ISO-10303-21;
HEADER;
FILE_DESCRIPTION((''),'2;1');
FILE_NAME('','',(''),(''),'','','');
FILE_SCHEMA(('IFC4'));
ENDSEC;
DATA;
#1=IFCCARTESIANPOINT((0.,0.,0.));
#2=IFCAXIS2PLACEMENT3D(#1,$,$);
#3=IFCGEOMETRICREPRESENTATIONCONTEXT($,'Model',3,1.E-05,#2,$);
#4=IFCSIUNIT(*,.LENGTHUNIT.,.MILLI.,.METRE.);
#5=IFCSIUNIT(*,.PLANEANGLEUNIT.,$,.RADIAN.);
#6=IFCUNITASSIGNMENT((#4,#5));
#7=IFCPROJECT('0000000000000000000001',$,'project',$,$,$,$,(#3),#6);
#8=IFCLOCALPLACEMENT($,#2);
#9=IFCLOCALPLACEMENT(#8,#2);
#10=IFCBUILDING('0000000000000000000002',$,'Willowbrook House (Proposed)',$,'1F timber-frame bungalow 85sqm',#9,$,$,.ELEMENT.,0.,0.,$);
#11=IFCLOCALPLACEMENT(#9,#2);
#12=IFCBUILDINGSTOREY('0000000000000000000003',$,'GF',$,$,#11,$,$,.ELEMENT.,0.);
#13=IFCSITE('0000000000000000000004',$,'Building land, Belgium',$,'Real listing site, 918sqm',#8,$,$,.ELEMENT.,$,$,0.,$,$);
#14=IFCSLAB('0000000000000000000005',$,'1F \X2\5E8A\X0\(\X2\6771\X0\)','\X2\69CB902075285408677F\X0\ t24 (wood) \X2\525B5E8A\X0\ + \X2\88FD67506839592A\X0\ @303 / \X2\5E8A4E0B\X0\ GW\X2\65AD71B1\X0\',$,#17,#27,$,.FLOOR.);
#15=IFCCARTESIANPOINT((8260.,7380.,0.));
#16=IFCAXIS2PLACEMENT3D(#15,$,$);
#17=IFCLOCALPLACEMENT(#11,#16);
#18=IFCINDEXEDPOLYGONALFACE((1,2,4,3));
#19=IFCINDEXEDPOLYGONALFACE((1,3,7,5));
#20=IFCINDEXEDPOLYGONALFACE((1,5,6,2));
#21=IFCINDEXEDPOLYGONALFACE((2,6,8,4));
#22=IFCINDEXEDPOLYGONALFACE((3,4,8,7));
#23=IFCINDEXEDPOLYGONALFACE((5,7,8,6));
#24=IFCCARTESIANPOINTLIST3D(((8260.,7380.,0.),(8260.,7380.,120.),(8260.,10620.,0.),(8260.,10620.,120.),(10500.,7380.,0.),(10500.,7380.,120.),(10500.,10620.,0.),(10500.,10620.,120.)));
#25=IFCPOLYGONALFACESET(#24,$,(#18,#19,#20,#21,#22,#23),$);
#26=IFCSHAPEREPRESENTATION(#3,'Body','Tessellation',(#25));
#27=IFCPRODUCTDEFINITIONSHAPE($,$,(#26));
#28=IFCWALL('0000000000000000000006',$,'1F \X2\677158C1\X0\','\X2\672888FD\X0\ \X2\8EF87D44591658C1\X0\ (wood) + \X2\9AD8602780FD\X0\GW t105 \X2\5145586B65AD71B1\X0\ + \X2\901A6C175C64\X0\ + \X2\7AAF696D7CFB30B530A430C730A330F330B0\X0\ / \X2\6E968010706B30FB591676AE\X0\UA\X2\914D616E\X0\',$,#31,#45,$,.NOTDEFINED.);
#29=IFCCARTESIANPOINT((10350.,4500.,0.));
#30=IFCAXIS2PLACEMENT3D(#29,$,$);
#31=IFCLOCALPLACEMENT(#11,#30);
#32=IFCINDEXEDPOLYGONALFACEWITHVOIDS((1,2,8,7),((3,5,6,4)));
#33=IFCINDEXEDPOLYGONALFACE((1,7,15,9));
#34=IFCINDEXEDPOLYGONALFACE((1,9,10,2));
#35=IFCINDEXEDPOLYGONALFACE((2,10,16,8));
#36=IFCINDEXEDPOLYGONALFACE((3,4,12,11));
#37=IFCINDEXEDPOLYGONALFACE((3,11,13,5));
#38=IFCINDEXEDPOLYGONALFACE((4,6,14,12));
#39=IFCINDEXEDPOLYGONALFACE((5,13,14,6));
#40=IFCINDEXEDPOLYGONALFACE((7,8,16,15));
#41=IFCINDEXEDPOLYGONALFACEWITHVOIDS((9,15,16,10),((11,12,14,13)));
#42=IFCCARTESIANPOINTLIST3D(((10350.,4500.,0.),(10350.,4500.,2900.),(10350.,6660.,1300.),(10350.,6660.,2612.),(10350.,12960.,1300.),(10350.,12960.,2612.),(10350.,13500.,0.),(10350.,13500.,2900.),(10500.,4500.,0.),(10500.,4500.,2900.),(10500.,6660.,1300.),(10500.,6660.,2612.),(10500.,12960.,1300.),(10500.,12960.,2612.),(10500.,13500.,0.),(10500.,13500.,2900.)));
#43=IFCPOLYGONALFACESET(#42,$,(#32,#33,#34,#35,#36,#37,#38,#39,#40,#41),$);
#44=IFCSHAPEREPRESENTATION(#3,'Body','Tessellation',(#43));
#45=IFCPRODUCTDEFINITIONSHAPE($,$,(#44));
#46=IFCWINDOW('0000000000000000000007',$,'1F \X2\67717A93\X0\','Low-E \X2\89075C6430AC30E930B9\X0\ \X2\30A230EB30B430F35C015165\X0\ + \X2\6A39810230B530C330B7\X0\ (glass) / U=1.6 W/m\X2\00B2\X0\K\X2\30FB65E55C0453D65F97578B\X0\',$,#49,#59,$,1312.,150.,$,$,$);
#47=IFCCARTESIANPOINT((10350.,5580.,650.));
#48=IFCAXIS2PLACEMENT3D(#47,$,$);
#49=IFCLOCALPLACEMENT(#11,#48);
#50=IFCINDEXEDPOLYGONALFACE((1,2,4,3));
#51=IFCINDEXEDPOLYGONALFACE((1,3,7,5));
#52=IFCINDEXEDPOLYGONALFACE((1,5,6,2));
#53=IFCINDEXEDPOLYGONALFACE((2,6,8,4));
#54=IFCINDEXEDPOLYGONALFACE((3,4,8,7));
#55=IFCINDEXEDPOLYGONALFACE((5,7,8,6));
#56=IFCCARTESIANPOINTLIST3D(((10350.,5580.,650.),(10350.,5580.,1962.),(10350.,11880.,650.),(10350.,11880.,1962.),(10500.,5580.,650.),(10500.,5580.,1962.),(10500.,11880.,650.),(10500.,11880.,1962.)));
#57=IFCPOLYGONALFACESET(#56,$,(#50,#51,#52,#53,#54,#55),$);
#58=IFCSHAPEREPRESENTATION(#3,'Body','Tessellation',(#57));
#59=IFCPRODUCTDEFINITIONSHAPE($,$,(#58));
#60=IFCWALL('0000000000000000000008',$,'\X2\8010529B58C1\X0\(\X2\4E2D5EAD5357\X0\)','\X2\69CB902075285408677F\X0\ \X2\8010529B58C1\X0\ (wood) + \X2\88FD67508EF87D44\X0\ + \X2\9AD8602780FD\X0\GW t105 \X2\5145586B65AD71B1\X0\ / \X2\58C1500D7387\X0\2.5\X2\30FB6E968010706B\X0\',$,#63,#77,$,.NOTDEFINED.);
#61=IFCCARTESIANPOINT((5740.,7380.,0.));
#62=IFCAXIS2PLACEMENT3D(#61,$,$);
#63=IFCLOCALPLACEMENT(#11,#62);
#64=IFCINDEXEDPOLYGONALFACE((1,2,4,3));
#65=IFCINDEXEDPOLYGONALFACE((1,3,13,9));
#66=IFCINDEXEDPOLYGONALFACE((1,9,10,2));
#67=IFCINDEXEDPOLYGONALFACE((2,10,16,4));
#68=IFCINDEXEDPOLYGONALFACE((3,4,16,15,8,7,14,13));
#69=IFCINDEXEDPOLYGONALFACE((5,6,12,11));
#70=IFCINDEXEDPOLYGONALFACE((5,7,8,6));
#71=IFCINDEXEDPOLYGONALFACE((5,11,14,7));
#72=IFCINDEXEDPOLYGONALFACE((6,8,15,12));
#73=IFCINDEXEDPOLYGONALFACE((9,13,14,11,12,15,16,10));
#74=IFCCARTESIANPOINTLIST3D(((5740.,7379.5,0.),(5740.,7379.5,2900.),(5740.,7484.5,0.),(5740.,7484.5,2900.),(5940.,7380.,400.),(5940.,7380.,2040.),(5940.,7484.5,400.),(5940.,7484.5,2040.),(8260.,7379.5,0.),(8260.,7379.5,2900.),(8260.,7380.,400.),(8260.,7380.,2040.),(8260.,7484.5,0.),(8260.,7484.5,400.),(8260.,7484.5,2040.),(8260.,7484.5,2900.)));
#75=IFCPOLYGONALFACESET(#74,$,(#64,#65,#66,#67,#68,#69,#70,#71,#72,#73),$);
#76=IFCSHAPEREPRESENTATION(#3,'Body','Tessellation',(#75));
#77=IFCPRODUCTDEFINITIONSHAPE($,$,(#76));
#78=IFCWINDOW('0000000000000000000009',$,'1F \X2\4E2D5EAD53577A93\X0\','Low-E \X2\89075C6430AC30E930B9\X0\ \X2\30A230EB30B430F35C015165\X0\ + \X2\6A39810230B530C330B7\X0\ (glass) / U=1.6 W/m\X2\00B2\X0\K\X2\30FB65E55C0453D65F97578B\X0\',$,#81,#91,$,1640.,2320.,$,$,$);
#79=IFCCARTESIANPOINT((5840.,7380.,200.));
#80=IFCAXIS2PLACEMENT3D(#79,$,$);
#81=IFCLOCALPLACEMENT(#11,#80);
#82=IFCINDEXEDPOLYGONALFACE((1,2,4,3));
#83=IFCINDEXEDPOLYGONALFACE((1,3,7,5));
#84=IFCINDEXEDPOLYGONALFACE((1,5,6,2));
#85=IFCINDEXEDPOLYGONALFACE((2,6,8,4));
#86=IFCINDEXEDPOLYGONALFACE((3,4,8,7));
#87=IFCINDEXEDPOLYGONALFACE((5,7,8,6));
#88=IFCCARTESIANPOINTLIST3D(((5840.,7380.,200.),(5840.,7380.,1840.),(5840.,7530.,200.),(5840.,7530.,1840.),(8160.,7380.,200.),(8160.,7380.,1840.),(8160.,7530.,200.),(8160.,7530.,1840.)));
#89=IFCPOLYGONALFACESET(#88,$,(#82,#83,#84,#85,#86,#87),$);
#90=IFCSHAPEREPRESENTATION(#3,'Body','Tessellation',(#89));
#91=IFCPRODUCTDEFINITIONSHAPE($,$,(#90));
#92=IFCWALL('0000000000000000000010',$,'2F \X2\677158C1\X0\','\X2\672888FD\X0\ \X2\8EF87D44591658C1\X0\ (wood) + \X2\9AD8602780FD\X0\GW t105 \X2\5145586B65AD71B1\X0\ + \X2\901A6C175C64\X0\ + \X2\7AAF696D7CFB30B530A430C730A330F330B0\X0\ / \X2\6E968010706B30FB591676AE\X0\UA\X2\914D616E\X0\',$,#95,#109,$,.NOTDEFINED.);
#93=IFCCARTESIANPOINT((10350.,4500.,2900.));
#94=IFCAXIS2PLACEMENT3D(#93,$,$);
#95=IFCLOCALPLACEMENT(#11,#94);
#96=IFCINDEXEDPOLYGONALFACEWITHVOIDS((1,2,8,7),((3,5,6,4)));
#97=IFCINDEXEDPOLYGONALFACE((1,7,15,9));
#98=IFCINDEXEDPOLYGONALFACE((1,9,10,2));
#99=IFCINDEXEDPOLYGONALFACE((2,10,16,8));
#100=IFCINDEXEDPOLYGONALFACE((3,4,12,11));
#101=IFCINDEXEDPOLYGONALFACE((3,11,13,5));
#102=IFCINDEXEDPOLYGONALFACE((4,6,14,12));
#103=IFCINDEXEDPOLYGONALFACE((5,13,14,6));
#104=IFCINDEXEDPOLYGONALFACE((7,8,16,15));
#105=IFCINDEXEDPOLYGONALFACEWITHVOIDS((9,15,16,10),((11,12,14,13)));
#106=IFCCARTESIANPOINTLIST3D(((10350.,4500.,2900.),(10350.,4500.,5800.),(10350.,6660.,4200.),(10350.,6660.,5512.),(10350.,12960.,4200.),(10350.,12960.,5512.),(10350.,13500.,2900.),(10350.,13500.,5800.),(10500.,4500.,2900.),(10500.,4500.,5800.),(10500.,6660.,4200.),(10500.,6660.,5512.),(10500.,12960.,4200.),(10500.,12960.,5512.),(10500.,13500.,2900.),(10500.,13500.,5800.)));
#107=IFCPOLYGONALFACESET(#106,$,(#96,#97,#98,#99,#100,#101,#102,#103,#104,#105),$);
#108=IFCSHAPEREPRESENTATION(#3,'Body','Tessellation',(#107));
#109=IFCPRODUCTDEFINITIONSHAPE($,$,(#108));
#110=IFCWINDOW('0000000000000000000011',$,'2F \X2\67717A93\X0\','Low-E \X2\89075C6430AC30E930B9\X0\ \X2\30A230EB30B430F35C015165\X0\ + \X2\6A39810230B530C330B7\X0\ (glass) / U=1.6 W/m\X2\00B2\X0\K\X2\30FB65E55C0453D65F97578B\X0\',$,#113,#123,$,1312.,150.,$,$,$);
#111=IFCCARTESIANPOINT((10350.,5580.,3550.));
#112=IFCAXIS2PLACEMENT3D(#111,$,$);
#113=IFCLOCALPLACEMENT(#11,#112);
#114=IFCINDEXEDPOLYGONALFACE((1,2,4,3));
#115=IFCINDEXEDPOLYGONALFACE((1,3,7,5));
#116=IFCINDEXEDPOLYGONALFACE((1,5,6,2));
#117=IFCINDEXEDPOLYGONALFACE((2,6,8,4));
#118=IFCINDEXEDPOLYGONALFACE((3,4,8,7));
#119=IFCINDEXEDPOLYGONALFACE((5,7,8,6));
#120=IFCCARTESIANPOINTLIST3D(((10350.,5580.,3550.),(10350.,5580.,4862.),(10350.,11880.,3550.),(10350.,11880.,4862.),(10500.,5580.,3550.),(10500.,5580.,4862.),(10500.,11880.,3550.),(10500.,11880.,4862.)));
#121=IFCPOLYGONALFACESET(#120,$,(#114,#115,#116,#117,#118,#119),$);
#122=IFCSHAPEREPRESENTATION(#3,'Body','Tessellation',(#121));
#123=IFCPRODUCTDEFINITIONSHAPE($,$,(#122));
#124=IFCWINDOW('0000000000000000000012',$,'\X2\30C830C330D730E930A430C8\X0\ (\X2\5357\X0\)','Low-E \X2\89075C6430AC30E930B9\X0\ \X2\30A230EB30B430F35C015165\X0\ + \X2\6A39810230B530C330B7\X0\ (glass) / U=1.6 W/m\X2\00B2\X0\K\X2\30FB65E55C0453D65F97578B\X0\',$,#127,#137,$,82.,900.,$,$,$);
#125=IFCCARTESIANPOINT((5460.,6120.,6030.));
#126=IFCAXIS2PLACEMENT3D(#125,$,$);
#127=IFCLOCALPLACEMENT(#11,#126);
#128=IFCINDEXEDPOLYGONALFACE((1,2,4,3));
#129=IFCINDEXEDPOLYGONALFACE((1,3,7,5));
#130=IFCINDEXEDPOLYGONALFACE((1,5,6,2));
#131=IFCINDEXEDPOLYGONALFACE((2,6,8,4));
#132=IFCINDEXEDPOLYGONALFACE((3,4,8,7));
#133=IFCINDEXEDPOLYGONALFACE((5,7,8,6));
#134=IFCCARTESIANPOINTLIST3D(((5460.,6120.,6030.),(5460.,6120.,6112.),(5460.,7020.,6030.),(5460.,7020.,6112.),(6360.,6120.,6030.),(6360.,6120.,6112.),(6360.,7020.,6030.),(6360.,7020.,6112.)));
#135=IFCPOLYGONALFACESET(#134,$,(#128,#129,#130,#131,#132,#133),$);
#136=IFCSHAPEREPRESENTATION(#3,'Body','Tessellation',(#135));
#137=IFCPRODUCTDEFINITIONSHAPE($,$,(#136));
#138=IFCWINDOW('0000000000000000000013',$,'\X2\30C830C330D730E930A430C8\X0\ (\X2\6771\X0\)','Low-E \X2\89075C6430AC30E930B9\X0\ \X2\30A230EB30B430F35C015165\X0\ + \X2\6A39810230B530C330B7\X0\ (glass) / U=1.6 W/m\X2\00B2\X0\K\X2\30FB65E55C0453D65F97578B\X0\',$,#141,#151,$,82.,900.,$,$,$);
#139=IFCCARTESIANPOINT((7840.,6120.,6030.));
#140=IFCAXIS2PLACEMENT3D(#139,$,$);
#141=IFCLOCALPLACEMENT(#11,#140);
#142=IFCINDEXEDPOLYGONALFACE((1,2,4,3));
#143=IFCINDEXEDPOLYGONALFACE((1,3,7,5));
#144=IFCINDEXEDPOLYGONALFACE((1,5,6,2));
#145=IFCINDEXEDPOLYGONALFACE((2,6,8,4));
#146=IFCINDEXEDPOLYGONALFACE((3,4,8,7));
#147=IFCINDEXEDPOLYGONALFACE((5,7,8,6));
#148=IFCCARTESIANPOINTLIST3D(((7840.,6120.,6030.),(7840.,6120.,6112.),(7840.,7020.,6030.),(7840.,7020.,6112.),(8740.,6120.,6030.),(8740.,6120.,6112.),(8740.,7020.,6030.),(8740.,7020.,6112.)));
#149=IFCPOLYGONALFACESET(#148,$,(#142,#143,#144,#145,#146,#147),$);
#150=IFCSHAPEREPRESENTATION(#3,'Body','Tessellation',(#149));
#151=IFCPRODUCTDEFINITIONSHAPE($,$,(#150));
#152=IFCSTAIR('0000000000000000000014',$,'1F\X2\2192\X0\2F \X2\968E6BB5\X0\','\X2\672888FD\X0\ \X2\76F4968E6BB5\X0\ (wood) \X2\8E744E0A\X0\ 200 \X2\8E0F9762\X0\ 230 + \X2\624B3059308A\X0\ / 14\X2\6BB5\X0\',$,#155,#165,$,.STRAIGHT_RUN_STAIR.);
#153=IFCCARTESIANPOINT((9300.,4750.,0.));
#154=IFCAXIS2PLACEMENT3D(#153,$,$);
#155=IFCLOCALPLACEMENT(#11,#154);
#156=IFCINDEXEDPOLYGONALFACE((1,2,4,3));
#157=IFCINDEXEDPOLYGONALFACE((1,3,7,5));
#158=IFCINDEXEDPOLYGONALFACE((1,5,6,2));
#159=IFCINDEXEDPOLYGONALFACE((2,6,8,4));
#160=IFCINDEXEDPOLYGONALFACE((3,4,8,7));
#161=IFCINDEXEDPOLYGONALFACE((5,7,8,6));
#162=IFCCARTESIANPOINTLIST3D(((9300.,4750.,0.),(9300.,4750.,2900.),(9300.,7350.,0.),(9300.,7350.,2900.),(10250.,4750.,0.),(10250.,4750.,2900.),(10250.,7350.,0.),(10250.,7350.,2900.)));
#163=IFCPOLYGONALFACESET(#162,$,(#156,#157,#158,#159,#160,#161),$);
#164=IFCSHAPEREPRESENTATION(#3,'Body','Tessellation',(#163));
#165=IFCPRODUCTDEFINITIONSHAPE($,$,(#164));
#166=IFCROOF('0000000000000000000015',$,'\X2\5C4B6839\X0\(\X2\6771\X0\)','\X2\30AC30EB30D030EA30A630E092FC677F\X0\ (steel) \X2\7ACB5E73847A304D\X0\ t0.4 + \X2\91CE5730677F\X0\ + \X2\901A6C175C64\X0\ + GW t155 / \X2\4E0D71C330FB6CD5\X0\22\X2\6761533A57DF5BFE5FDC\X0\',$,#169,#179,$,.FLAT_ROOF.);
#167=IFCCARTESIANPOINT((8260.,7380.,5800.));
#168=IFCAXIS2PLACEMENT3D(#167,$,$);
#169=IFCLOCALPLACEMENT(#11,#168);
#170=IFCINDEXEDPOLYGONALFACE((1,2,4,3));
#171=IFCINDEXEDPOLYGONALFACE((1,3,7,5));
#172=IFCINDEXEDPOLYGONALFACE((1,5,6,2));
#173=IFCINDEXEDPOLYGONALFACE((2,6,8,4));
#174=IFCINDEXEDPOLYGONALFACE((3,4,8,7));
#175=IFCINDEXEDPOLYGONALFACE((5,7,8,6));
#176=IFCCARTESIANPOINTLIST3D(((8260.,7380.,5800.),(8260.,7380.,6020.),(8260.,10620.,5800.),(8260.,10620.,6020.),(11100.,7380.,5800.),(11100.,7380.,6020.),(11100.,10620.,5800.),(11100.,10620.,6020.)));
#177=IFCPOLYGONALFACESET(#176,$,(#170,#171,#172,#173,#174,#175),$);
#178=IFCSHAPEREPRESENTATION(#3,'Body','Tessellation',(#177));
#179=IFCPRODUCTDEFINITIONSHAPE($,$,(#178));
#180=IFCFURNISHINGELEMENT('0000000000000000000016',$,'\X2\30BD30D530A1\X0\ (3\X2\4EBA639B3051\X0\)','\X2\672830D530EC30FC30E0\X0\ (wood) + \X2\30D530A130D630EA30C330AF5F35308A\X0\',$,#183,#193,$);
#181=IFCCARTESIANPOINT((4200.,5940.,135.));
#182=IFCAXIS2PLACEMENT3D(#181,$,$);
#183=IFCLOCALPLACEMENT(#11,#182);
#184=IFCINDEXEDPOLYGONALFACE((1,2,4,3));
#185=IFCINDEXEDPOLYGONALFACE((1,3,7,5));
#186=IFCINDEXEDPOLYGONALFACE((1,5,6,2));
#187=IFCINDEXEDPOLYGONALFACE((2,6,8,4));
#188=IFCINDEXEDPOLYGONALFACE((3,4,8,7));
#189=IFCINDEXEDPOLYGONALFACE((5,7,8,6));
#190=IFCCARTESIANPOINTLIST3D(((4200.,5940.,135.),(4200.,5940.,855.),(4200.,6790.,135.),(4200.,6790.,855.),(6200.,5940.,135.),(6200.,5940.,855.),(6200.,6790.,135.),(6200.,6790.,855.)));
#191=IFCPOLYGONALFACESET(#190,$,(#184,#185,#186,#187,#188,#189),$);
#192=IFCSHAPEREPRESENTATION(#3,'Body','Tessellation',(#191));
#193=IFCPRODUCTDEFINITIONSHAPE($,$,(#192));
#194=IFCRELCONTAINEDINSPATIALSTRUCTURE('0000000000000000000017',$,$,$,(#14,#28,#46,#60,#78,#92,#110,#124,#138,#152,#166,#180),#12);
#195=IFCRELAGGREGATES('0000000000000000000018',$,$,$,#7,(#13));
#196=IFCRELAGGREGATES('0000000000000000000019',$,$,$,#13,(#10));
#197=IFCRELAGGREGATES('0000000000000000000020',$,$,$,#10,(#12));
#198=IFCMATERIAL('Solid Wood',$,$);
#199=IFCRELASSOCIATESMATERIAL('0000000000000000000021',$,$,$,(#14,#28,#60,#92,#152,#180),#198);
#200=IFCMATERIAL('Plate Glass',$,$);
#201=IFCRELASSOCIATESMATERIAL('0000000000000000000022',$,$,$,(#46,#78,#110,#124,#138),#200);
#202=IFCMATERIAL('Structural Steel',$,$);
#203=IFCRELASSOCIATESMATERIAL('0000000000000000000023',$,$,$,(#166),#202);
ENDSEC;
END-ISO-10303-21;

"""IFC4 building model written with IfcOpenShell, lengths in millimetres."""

from ifc_helpers import new_model, si_unit, frame, frame_2d, origin, place, context, project, spatial, rectangle, extrude, material, element, fill, save


model = new_model("IFC4")

# Units and contexts
model_context = context("Model", 3, precision=1e-05, world=origin())
ifc_project = project(units=[si_unit("LENGTHUNIT", "METRE", prefix="MILLI"), si_unit("PLANEANGLEUNIT", "RADIAN")], contexts=[model_context])

# Site, building, storey
site_placement = place(None, origin())
site = spatial("IfcSite", under=ifc_project, at=site_placement, Name="Building land, Belgium", ObjectType="Real listing site, 918sqm", CompositionType="ELEMENT", RefElevation=0.0)
building_placement = place(site_placement, origin())
building = spatial("IfcBuilding", under=site, at=building_placement, Name="Willowbrook House (Proposed)", ObjectType="1F timber-frame bungalow 85sqm", CompositionType="ELEMENT", ElevationOfRefHeight=0.0, ElevationOfTerrain=0.0)
storey_placement = place(building_placement, origin())
storey = spatial("IfcBuildingStorey", under=building, at=storey_placement, Name="GF", CompositionType="ELEMENT", Elevation=0.0)

# Slab
ifc_material_1 = material(Name="Solid Wood")
slab_placement = place(storey_placement, frame((8260.0, 7380.0, 0.0)))
element("IfcSlab", 1, at=slab_placement, inside=storey, material=ifc_material_1, Name="1F 床(東)", Description="構造用合板 t24 (wood) 剛床 + 製材根太 @303 / 床下 GW断熱", PredefinedType="FLOOR", context=model_context, shape_type="SweptSolid", body=[
    extrude(rectangle(XDim=2240.0, YDim=3240.0, at=frame_2d((1120.0, 1620.0))), frame((8260.0, 7380.0, 0.0)), (0.0, 0.0, 1.0), 120.0),
])

# Walls, openings, windows
wall_1_placement = place(storey_placement, frame((10350.0, 4500.0, 0.0)))
wall_1 = element("IfcWall", 2, at=wall_1_placement, inside=storey, material=ifc_material_1, Name="1F 東壁", Description="木製 軸組外壁 (wood) + 高性能GW t105 充填断熱 + 通気層 + 窯業系サイディング / 準耐火・外皮UA配慮", PredefinedType="NOTDEFINED", context=model_context, shape_type="SweptSolid", body=[
    extrude(rectangle(XDim=150.0, YDim=9000.0, at=frame_2d((75.0, 4500.0))), frame((10350.0, 4500.0, 0.0)), (0.0, 0.0, 1.0), 2900.0),
])
opening_1_placement = place(storey_placement, frame((10350.0, 5580.0, 650.0)))
opening_1 = element("IfcOpeningElement", 3, at=opening_1_placement, cuts=wall_1, PredefinedType="NOTDEFINED", context=model_context, shape_type="SweptSolid", body=[
    extrude(rectangle(XDim=150.0, YDim=6300.0, at=frame_2d((75.0, 3150.0))), frame((10350.0, 5580.0, 650.0)), (0.0, 0.0, 1.0), 1312.0),
])
ifc_material_2 = material(Name="Plate Glass")
window_1_placement = place(storey_placement, frame((10350.0, 5580.0, 650.0)))
window_1 = element("IfcWindow", 4, at=window_1_placement, inside=storey, material=ifc_material_2, Name="1F 東窓", Description="Low-E 複層ガラス アルゴン封入 + 樹脂サッシ (glass) / U=1.6 W/m²K・日射取得型", OverallHeight=1312.0, OverallWidth=150.0, context=model_context, shape_type="SweptSolid", body=[
    extrude(rectangle(XDim=150.0, YDim=6300.0, at=frame_2d((75.0, 3150.0))), frame((10350.0, 5580.0, 650.0)), (0.0, 0.0, 1.0), 1312.0),
])
fill(opening_1, window_1)
wall_2_placement = place(storey_placement, frame((5740.0, 7380.0, 0.0)))
wall_2 = element("IfcWall", 5, at=wall_2_placement, inside=storey, material=ifc_material_1, Name="耐力壁(中庭南)", Description="構造用合板 耐力壁 (wood) + 製材軸組 + 高性能GW t105 充填断熱 / 壁倍率2.5・準耐火", PredefinedType="NOTDEFINED", context=model_context, shape_type="SweptSolid", body=[
    extrude(rectangle(XDim=2520.0, YDim=105.0, at=frame_2d((1260.0, 52.0))), frame((5740.0, 7380.0, 0.0)), (0.0, 0.0, 1.0), 2900.0),
])
opening_2_placement = place(storey_placement, frame((5840.0, 7380.0, 200.0)))
opening_2 = element("IfcOpeningElement", 6, at=opening_2_placement, cuts=wall_2, PredefinedType="NOTDEFINED", context=model_context, shape_type="SweptSolid", body=[
    extrude(rectangle(XDim=2320.0, YDim=150.0, at=frame_2d((1160.0, 75.0))), frame((5840.0, 7380.0, 200.0)), (0.0, 0.0, 1.0), 1640.0),
])
window_2_placement = place(storey_placement, frame((5840.0, 7380.0, 200.0)))
window_2 = element("IfcWindow", 7, at=window_2_placement, inside=storey, material=ifc_material_2, Name="1F 中庭南窓", Description="Low-E 複層ガラス アルゴン封入 + 樹脂サッシ (glass) / U=1.6 W/m²K・日射取得型", OverallHeight=1640.0, OverallWidth=2320.0, context=model_context, shape_type="SweptSolid", body=[
    extrude(rectangle(XDim=2320.0, YDim=150.0, at=frame_2d((1160.0, 75.0))), frame((5840.0, 7380.0, 200.0)), (0.0, 0.0, 1.0), 1640.0),
])
fill(opening_2, window_2)

# Wall, opening, window
wall_3_placement = place(storey_placement, frame((10350.0, 4500.0, 2900.0)))
wall_3 = element("IfcWall", 8, at=wall_3_placement, inside=storey, material=ifc_material_1, Name="2F 東壁", Description="木製 軸組外壁 (wood) + 高性能GW t105 充填断熱 + 通気層 + 窯業系サイディング / 準耐火・外皮UA配慮", PredefinedType="NOTDEFINED", context=model_context, shape_type="SweptSolid", body=[
    extrude(rectangle(XDim=150.0, YDim=9000.0, at=frame_2d((75.0, 4500.0))), frame((10350.0, 4500.0, 2900.0)), (0.0, 0.0, 1.0), 2900.0),
])
opening_3_placement = place(storey_placement, frame((10350.0, 5580.0, 3550.0)))
opening_3 = element("IfcOpeningElement", 9, at=opening_3_placement, cuts=wall_3, PredefinedType="NOTDEFINED", context=model_context, shape_type="SweptSolid", body=[
    extrude(rectangle(XDim=150.0, YDim=6300.0, at=frame_2d((75.0, 3150.0))), frame((10350.0, 5580.0, 3550.0)), (0.0, 0.0, 1.0), 1312.0),
])
window_3_placement = place(storey_placement, frame((10350.0, 5580.0, 3550.0)))
window_3 = element("IfcWindow", 10, at=window_3_placement, inside=storey, material=ifc_material_2, Name="2F 東窓", Description="Low-E 複層ガラス アルゴン封入 + 樹脂サッシ (glass) / U=1.6 W/m²K・日射取得型", OverallHeight=1312.0, OverallWidth=150.0, context=model_context, shape_type="SweptSolid", body=[
    extrude(rectangle(XDim=150.0, YDim=6300.0, at=frame_2d((75.0, 3150.0))), frame((10350.0, 5580.0, 3550.0)), (0.0, 0.0, 1.0), 1312.0),
])
fill(opening_3, window_3)

# Windows
window_4_placement = place(storey_placement, frame((5460.0, 6120.0, 6030.0)))
element("IfcWindow", 11, at=window_4_placement, inside=storey, material=ifc_material_2, Name="トップライト (南)", Description="Low-E 複層ガラス アルゴン封入 + 樹脂サッシ (glass) / U=1.6 W/m²K・日射取得型", OverallHeight=82.0, OverallWidth=900.0, context=model_context, shape_type="SweptSolid", body=[
    extrude(rectangle(XDim=900.0, YDim=900.0, at=frame_2d((450.0, 450.0))), frame((5460.0, 6120.0, 6030.0)), (0.0, 0.0, 1.0), 82.0),
])
window_5_placement = place(storey_placement, frame((7840.0, 6120.0, 6030.0)))
element("IfcWindow", 12, at=window_5_placement, inside=storey, material=ifc_material_2, Name="トップライト (東)", Description="Low-E 複層ガラス アルゴン封入 + 樹脂サッシ (glass) / U=1.6 W/m²K・日射取得型", OverallHeight=82.0, OverallWidth=900.0, context=model_context, shape_type="SweptSolid", body=[
    extrude(rectangle(XDim=900.0, YDim=900.0, at=frame_2d((450.0, 450.0))), frame((7840.0, 6120.0, 6030.0)), (0.0, 0.0, 1.0), 82.0),
])

# Stair
stair_placement = place(storey_placement, frame((9300.0, 4750.0, 0.0)))
element("IfcStair", 13, at=stair_placement, inside=storey, material=ifc_material_1, Name="1F→2F 階段", Description="木製 直階段 (wood) 蹴上 200 踏面 230 + 手すり / 14段", PredefinedType="STRAIGHT_RUN_STAIR", context=model_context, shape_type="SweptSolid", body=[
    extrude(rectangle(XDim=950.0, YDim=2600.0, at=frame_2d((475.0, 1300.0))), frame((9300.0, 4750.0, 0.0)), (0.0, 0.0, 1.0), 2900.0),
])

# Roof
ifc_material_3 = material(Name="Structural Steel")
roof_placement = place(storey_placement, frame((8260.0, 7380.0, 5800.0)))
element("IfcRoof", 14, at=roof_placement, inside=storey, material=ifc_material_3, Name="屋根(東)", Description="ガルバリウム鋼板 (steel) 立平葺き t0.4 + 野地板 + 通気層 + GW t155 / 不燃・法22条区域対応", PredefinedType="FLAT_ROOF", context=model_context, shape_type="SweptSolid", body=[
    extrude(rectangle(XDim=2840.0, YDim=3240.0, at=frame_2d((1420.0, 1620.0))), frame((8260.0, 7380.0, 5800.0)), (0.0, 0.0, 1.0), 220.0),
])

# Furnishing element
furnishing_1_placement = place(storey_placement, frame((4200.0, 5940.0, 135.0)))
element("IfcFurnishingElement", 15, at=furnishing_1_placement, inside=storey, material=ifc_material_1, Name="ソファ (3人掛け)", Description="木フレーム (wood) + ファブリック張り", context=model_context, shape_type="SweptSolid", body=[
    extrude(rectangle(XDim=2000.0, YDim=850.0, at=frame_2d((1000.0, 425.0))), frame((4200.0, 5940.0, 135.0)), (0.0, 0.0, 1.0), 720.0),
])

save(model, "model.ifc")
